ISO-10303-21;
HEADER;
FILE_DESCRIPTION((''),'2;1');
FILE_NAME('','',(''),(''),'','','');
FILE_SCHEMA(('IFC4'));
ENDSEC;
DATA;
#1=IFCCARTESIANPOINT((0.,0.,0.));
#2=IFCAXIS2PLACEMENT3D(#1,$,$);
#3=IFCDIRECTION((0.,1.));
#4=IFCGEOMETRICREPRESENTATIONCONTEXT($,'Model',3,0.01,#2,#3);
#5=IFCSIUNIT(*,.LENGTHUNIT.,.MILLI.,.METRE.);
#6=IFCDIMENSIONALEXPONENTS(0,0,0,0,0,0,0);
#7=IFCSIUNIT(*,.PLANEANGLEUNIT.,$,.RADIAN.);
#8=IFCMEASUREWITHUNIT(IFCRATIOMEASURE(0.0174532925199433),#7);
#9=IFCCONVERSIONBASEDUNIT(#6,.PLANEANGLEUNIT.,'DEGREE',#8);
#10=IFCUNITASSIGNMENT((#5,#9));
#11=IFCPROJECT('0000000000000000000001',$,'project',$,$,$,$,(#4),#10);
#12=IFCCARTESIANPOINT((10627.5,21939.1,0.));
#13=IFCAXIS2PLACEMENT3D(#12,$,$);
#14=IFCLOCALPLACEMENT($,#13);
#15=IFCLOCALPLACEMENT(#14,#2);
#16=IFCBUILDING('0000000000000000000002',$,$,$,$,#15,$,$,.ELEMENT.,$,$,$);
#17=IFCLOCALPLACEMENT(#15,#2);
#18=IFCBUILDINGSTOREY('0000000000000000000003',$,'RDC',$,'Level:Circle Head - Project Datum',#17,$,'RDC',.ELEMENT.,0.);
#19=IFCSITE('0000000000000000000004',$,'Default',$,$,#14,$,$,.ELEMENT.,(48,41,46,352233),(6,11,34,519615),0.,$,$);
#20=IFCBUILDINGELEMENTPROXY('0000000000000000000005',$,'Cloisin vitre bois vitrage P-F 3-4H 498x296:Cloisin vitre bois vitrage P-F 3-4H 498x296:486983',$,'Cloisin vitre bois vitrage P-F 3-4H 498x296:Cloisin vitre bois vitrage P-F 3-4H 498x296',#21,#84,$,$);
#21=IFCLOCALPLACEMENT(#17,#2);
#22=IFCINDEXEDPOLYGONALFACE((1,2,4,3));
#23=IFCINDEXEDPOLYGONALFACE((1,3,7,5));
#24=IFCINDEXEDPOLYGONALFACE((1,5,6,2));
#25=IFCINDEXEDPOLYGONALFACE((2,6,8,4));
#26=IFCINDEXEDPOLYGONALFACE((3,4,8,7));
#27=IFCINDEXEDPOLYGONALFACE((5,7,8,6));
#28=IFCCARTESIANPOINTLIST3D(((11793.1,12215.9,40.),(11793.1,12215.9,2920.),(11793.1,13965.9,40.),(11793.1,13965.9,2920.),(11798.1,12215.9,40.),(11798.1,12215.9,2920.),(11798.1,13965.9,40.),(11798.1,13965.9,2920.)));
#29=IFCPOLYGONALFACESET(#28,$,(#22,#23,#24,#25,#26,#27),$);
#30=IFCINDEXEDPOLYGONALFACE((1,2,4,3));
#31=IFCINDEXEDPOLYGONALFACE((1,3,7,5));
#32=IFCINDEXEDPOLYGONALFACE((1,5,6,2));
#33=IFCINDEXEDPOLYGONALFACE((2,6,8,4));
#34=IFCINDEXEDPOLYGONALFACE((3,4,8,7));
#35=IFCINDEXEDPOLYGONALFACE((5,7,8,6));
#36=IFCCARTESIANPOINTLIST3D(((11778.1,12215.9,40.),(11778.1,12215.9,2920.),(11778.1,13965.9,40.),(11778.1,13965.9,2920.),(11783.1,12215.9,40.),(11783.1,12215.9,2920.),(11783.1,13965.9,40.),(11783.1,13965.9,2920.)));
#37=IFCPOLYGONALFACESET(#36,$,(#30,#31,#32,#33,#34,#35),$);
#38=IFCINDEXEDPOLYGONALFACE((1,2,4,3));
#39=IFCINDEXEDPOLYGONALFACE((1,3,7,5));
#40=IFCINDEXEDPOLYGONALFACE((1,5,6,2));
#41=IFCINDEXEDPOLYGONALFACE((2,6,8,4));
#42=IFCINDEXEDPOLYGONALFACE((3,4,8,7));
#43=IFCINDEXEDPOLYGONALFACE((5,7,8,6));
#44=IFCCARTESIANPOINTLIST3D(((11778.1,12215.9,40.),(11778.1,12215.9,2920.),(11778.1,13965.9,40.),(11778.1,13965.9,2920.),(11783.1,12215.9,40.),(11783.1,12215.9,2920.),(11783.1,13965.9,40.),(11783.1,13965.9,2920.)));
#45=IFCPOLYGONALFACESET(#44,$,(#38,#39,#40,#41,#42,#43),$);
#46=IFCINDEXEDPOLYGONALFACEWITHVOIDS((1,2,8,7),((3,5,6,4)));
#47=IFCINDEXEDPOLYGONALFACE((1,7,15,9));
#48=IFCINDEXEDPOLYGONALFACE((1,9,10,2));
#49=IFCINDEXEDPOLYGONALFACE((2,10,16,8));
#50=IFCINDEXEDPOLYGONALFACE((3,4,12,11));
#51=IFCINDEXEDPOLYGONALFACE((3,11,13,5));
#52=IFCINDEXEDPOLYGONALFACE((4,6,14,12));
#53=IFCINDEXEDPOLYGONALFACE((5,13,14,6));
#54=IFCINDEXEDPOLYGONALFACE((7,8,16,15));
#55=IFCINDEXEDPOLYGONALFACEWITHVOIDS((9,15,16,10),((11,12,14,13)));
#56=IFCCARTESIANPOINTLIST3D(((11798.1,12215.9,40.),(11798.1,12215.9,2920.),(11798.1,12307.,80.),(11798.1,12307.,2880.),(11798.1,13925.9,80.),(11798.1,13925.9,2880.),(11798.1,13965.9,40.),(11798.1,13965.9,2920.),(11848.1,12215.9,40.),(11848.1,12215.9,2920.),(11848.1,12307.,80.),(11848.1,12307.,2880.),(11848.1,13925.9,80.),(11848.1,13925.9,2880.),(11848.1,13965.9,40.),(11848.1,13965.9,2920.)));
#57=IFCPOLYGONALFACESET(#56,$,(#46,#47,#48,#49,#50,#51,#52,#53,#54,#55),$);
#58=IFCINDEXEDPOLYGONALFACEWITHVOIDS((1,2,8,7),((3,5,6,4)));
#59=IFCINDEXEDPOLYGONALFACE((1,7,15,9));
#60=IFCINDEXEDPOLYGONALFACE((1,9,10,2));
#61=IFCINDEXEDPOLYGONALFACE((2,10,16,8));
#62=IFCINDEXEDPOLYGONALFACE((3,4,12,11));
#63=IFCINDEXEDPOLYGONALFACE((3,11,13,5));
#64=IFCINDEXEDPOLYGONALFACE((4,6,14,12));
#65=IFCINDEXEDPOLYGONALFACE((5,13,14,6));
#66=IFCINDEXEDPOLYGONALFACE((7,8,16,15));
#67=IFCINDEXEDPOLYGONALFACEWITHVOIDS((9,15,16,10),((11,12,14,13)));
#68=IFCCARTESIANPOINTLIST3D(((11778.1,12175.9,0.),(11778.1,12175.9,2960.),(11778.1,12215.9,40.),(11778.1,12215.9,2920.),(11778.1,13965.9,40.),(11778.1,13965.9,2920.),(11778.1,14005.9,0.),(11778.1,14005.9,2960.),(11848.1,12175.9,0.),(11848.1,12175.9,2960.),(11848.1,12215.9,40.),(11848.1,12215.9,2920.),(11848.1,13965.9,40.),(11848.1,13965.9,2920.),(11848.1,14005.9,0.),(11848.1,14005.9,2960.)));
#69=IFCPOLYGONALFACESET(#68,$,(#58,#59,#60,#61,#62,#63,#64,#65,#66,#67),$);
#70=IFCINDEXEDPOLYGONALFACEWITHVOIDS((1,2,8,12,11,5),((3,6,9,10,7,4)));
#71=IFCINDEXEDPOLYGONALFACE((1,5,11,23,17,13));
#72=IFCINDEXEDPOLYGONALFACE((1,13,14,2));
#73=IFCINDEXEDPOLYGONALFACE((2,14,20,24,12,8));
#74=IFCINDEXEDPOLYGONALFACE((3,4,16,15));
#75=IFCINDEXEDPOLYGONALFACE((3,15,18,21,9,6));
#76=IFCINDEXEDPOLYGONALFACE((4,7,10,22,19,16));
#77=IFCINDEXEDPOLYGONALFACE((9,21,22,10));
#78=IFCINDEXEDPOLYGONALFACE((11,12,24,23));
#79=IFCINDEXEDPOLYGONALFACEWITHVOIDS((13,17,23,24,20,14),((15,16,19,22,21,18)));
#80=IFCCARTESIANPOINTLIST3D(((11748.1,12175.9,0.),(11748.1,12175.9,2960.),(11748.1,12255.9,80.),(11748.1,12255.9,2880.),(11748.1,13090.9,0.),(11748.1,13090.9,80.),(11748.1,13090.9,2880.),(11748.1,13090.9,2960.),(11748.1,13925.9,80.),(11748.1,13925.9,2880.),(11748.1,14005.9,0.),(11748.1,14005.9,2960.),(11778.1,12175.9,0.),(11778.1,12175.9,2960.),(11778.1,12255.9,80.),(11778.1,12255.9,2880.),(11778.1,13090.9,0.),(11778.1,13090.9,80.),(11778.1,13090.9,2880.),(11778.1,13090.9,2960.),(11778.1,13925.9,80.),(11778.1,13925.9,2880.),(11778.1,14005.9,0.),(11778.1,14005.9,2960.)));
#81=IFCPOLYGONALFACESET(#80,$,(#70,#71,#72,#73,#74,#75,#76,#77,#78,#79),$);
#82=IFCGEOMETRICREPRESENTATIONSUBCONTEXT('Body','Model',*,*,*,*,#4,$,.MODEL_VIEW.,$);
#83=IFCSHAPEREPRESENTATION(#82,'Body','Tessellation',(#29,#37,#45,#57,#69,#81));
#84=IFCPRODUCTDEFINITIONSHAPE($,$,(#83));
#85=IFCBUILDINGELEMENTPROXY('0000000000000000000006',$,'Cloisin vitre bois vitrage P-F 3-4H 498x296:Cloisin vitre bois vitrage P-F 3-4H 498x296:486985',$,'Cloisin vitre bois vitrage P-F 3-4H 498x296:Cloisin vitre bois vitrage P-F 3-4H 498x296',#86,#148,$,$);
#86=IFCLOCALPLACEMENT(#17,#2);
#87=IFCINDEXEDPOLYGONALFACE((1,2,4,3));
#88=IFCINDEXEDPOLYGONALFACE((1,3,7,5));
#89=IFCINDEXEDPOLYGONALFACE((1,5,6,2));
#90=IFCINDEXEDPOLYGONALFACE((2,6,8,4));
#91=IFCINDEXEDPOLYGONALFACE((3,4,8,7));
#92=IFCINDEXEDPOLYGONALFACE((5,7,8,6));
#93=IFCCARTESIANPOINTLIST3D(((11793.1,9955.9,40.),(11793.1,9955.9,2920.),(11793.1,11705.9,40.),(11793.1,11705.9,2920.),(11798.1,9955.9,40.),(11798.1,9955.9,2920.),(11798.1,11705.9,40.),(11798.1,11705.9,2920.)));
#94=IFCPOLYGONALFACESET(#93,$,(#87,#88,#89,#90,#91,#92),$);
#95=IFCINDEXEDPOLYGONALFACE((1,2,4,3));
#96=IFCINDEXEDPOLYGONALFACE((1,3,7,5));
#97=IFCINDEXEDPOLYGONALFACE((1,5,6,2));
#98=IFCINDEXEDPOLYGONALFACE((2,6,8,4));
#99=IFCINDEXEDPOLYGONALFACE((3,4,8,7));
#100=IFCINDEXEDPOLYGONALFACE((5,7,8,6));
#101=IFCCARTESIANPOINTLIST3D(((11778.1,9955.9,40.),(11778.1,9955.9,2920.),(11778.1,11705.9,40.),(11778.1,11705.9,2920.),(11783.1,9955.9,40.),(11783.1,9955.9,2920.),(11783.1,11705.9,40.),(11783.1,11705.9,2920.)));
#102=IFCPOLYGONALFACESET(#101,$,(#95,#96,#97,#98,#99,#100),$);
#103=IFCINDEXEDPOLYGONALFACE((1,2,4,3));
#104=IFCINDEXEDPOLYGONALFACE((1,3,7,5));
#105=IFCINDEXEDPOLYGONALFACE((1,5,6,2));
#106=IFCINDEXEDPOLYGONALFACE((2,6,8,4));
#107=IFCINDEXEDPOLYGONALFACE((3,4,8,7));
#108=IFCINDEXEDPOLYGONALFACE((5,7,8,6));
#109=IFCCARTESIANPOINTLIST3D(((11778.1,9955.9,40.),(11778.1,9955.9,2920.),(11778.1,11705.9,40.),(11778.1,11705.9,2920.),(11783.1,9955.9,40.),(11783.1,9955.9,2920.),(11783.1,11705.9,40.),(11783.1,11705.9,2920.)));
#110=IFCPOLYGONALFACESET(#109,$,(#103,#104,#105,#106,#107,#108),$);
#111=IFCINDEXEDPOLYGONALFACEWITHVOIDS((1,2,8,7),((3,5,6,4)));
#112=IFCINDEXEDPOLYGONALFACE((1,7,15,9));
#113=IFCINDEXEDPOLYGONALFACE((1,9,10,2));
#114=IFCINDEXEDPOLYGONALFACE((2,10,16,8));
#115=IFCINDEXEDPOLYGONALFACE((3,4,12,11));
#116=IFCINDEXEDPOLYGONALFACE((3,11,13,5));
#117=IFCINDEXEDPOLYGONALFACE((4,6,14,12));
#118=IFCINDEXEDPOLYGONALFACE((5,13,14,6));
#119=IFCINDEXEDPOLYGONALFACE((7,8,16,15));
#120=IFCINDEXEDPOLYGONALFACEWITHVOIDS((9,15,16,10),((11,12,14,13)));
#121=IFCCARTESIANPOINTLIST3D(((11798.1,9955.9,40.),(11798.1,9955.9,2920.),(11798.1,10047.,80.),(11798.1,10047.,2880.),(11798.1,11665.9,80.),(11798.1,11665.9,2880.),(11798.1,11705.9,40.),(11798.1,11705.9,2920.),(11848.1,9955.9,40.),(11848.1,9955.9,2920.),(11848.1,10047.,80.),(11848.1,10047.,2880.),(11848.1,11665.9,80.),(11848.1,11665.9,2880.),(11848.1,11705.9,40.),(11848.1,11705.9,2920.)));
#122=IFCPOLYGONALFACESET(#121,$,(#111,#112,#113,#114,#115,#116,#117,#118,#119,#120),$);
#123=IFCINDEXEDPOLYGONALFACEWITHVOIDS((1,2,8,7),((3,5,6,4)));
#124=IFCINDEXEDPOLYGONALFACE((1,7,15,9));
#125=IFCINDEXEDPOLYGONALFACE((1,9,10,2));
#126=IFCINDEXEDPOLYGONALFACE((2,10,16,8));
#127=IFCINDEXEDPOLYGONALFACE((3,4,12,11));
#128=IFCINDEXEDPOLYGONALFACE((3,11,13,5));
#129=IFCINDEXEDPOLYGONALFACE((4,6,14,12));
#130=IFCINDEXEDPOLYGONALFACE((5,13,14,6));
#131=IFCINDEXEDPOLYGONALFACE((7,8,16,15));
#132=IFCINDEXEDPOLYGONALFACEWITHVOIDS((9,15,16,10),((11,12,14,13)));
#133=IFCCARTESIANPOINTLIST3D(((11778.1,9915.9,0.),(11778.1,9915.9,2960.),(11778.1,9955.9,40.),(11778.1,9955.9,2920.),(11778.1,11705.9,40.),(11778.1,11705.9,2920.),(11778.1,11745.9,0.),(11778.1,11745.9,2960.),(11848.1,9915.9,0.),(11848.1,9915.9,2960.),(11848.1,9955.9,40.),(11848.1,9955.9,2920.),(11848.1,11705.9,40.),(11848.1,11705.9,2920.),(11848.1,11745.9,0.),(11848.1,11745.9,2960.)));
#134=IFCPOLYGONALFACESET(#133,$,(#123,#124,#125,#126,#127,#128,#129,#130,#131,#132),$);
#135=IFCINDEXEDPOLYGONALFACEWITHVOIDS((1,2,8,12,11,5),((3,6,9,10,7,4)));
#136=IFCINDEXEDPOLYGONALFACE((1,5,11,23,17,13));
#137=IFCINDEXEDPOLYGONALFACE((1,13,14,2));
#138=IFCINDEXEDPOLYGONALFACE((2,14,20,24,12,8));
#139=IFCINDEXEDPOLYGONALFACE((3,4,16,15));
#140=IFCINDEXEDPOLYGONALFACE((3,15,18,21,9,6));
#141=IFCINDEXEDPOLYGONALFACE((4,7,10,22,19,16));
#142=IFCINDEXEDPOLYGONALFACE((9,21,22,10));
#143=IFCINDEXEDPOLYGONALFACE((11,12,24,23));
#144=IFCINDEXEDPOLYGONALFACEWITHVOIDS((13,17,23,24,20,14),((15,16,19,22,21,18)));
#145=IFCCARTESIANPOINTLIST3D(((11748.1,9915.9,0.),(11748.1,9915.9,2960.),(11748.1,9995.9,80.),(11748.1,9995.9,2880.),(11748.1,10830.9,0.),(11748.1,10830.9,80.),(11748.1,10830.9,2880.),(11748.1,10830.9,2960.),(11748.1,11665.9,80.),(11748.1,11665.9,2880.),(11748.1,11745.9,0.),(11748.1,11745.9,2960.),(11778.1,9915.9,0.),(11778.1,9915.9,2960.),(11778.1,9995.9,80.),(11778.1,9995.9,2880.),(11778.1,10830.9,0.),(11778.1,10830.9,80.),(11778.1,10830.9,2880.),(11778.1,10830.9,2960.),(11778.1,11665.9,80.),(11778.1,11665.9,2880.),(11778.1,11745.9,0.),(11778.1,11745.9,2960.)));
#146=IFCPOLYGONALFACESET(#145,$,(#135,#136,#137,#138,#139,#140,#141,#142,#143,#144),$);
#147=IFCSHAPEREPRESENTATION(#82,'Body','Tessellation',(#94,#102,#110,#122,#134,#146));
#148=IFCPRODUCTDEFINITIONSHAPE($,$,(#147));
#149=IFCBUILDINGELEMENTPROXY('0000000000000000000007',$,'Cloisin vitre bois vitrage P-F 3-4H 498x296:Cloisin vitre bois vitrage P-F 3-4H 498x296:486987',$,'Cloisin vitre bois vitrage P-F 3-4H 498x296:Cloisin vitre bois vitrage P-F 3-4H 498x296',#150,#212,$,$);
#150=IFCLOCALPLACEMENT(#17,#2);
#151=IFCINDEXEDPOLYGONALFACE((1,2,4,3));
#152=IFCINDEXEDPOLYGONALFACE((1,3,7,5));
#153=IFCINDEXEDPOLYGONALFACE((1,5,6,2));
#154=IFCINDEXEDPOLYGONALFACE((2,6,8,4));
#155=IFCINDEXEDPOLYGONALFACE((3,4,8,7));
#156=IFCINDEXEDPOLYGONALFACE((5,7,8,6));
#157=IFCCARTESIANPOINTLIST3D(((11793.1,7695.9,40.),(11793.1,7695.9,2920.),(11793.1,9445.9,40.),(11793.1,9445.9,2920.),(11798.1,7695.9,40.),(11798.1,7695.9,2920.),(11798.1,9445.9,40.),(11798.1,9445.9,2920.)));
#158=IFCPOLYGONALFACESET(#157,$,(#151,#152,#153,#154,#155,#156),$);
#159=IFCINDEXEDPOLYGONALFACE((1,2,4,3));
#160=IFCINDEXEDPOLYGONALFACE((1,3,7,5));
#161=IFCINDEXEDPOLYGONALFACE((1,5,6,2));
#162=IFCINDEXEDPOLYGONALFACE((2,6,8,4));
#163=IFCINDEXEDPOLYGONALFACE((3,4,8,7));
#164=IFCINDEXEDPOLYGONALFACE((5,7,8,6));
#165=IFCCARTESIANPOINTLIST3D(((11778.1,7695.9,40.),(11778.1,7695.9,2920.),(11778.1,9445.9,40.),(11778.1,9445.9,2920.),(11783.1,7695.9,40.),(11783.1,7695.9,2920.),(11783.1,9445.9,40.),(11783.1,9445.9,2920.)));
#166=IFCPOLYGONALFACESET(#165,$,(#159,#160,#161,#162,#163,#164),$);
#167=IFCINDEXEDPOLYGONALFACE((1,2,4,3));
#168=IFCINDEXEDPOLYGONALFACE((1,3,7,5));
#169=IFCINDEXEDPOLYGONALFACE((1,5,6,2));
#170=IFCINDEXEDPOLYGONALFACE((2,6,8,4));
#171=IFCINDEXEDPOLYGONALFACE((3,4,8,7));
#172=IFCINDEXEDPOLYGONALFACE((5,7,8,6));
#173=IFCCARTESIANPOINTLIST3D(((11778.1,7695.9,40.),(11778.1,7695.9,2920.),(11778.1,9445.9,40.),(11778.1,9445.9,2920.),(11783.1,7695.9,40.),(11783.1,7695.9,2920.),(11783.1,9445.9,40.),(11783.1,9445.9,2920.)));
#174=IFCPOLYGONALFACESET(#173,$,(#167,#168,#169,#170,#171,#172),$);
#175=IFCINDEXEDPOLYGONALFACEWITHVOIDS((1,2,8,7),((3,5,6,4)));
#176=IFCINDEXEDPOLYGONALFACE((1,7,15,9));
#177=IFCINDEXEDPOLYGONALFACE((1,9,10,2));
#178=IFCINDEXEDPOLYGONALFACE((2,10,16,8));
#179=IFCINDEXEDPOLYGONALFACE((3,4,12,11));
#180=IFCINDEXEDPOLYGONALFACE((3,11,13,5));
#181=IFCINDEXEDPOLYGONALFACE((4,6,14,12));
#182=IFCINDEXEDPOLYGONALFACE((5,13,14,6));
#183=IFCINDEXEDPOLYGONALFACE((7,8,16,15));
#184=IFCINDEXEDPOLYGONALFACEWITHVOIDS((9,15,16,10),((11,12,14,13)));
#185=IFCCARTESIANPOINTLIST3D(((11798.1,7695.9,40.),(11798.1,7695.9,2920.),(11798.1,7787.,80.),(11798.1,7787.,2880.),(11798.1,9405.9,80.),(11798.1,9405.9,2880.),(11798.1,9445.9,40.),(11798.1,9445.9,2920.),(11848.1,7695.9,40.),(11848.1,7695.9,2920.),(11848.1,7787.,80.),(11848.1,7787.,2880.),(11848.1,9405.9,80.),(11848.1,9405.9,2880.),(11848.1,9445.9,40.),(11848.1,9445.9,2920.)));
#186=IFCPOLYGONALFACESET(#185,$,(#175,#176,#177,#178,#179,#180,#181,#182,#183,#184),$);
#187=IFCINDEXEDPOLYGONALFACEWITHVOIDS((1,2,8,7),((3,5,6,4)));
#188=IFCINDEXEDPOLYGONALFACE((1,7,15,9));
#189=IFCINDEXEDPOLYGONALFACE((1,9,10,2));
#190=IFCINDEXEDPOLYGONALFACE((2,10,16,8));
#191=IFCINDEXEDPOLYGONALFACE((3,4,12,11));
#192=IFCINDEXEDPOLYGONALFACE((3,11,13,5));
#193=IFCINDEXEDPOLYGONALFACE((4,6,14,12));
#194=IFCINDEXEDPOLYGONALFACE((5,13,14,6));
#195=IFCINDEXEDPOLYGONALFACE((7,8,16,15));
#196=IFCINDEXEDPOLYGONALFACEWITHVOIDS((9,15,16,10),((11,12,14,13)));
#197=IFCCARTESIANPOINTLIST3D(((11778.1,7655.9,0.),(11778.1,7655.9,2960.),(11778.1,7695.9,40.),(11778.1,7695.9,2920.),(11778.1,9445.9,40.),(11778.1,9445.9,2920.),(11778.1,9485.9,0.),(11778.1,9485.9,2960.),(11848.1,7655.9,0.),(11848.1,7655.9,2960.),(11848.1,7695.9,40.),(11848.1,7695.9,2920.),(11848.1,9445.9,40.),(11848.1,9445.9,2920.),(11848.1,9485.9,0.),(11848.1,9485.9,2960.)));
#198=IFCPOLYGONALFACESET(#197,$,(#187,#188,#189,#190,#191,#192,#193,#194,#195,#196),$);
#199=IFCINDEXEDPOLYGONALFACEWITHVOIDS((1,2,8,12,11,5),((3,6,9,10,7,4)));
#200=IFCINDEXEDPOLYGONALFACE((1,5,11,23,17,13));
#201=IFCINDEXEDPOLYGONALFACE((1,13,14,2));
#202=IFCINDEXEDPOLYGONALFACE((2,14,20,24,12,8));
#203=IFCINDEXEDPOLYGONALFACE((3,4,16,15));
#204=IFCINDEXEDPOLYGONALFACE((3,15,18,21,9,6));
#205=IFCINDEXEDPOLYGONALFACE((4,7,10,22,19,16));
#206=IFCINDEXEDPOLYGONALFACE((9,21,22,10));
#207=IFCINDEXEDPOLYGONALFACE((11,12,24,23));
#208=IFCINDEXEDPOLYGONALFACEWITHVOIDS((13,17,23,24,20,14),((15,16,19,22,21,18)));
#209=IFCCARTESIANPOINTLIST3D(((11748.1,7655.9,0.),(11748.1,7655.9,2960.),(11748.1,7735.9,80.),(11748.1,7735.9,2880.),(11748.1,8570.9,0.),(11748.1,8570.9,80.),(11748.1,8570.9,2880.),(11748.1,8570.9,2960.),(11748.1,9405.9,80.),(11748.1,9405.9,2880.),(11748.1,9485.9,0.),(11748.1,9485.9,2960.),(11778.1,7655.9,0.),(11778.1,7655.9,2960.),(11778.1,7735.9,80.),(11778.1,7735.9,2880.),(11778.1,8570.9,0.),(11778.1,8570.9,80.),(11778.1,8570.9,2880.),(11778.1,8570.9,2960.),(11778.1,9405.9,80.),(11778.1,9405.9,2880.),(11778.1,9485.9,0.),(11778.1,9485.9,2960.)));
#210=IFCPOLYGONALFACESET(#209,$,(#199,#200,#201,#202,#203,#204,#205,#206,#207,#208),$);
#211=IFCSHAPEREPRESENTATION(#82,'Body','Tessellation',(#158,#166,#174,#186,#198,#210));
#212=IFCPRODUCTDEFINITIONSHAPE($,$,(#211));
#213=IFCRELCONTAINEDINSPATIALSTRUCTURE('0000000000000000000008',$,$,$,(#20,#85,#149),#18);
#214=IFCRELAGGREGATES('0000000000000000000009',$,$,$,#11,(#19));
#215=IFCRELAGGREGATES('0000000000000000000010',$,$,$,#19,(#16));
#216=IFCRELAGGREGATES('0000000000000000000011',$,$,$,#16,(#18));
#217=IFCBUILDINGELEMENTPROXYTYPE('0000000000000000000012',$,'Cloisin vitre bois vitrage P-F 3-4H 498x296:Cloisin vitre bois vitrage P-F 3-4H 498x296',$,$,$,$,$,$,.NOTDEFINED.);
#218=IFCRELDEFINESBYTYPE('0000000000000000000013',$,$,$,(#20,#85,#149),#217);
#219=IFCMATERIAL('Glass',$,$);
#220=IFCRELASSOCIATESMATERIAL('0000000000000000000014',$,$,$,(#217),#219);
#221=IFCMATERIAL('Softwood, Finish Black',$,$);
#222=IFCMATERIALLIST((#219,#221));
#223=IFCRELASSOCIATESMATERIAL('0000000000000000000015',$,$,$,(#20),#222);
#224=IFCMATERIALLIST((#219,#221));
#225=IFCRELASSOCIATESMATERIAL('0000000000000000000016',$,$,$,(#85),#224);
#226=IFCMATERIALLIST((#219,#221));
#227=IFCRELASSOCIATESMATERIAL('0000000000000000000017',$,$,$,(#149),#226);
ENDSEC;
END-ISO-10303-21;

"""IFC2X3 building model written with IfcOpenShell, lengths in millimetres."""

from ifc_helpers import new_model, entity, si_unit, converted_unit, direction, frame, frame_2d, origin, place, context, subcontext, project, spatial, polyline, rectangle, outline, extrude, source, transform, mapped, material, material_list, type_object, type_shapes, element, save


model = new_model("IFC2X3")

# Units and contexts
model_context = context("Model", 3, precision=0.01, world=origin(), true_north=direction((0.0, 1.0)))
body_context = subcontext(model_context, "Body", "Model", "MODEL_VIEW")
ifc_project = project(units=[si_unit("LENGTHUNIT", "METRE", prefix="MILLI"), converted_unit("PLANEANGLEUNIT", "DEGREE", entity("IfcRatioMeasure", 0.0174532925199433), si_unit("PLANEANGLEUNIT", "RADIAN"), dimensions=[0, 0, 0, 0, 0, 0, 0])], contexts=[model_context])

# Site, building, storey
site_placement = place(None, frame((10627.5, 21939.1, 0.0)))
site = spatial("IfcSite", under=ifc_project, at=site_placement, Name="Default", CompositionType="ELEMENT", RefLatitude=(48, 41, 46, 352233), RefLongitude=(6, 11, 34, 519615), RefElevation=0.0)
building_placement = place(site_placement, origin())
building = spatial("IfcBuilding", under=site, at=building_placement, CompositionType="ELEMENT")
storey_placement = place(building_placement, origin())
storey = spatial("IfcBuildingStorey", under=building, at=storey_placement, Name="RDC", ObjectType="Level:Circle Head - Project Datum", LongName="RDC", CompositionType="ELEMENT", Elevation=0.0)

# Building element proxies
ifc_material_1 = material(Name="Glass")
ifc_material_2 = material(Name="Softwood, Finish Black")
ifc_material_list_1 = material_list([ifc_material_1, ifc_material_2])
building_element_proxy_type_1 = type_object("IfcBuildingElementProxyType", Name="Cloisin vitre bois vitrage P-F 3-4H 498x296:Cloisin vitre bois vitrage P-F 3-4H 498x296", PredefinedType="NOTDEFINED", material=ifc_material_1)
shared_shape_1 = source(origin(), body_context, "Body", "SweptSolid", [
    extrude(rectangle(XDim=1750.0, YDim=5.0, at=frame_2d((0.0, 0.0), x_axis=(1.0, 0.0))), frame((0.0, 47.5, 40.0), z_axis=(0.0, 0.0, 1.0), x_axis=(-1.0, 0.0, 0.0)), (0.0, 0.0, 1.0), 2880.0),
    extrude(rectangle(XDim=1750.0, YDim=5.0, at=frame_2d((0.0, 0.0), x_axis=(1.0, 0.0))), frame((0.0, 32.5, 40.0), z_axis=(0.0, 0.0, 1.0), x_axis=(-1.0, 0.0, 0.0)), (0.0, 0.0, 1.0), 2880.0),
    extrude(rectangle(XDim=1750.0, YDim=5.0, at=frame_2d((0.0, 0.0), x_axis=(1.0, 0.0))), frame((0.0, 32.5, 40.0), z_axis=(0.0, 0.0, 1.0), x_axis=(-1.0, 0.0, 0.0)), (0.0, 0.0, 1.0), 2880.0),
    extrude(outline(polyline([(-1440.0, -875.0), (1440.0, -875.0), (1440.0, 875.0), (-1440.0, 875.0), (-1440.0, -875.0)]), holes=[polyline([(1400.0, 835.0), (1400.0, -783.9), (-1400.0, -783.9), (-1400.0, 835.0), (1400.0, 835.0)])]), frame((0.0, 50.0, 1480.0), z_axis=(0.0, 1.0, 0.0), x_axis=(0.0, 0.0, -1.0)), (0.0, 0.0, 1.0), 50.0),
    extrude(outline(polyline([(-1480.0, -915.0), (1480.0, -915.0), (1480.0, 915.0), (-1480.0, 915.0), (-1480.0, -915.0)]), holes=[polyline([(-1440.0, -875.0), (-1440.0, 875.0), (1440.0, 875.0), (1440.0, -875.0), (-1440.0, -875.0)])]), frame((0.0, 30.0, 1480.0), z_axis=(0.0, 1.0, 0.0), x_axis=(0.0, 0.0, -1.0)), (0.0, 0.0, 1.0), 70.0),
    extrude(outline(polyline([(-1480.0, -915.0), (1480.0, -915.0), (1480.0, 0.0), (1480.0, 915.0), (-1480.0, 915.0), (-1480.0, 0.0), (-1480.0, -915.0)]), holes=[polyline([(1400.0, 0.0), (1400.0, -835.0), (-1400.0, -835.0), (-1400.0, 0.0), (-1400.0, 835.0), (1400.0, 835.0), (1400.0, 0.0)])]), frame((0.0, 0.0, 1480.0), z_axis=(0.0, 1.0, 0.0), x_axis=(0.0, 0.0, 1.0)), (0.0, 0.0, 1.0), 30.0),
])
type_shapes(building_element_proxy_type_1, [shared_shape_1])
proxy_1_placement = place(storey_placement, frame((11748.1, 13090.9, 0.0), z_axis=(0.0, 0.0, 1.0), x_axis=(0.0, -1.0, 0.0)))
element("IfcBuildingElementProxy", 1, at=proxy_1_placement, inside=storey, type_object=building_element_proxy_type_1, material=ifc_material_list_1, Name="Cloisin vitre bois vitrage P-F 3-4H 498x296:Cloisin vitre bois vitrage P-F 3-4H 498x296:486983", ObjectType="Cloisin vitre bois vitrage P-F 3-4H 498x296:Cloisin vitre bois vitrage P-F 3-4H 498x296", context=body_context, shape_type="MappedRepresentation", body=[
    mapped(shared_shape_1, transform((0.0, 0.0, 0.0), scale=1.0)),
])
ifc_material_list_2 = material_list([ifc_material_1, ifc_material_2])
proxy_2_placement = place(storey_placement, frame((11748.1, 10830.9, 0.0), z_axis=(0.0, 0.0, 1.0), x_axis=(0.0, -1.0, 0.0)))
element("IfcBuildingElementProxy", 2, at=proxy_2_placement, inside=storey, type_object=building_element_proxy_type_1, material=ifc_material_list_2, Name="Cloisin vitre bois vitrage P-F 3-4H 498x296:Cloisin vitre bois vitrage P-F 3-4H 498x296:486985", ObjectType="Cloisin vitre bois vitrage P-F 3-4H 498x296:Cloisin vitre bois vitrage P-F 3-4H 498x296", context=body_context, shape_type="MappedRepresentation", body=[
    mapped(shared_shape_1, transform((0.0, 0.0, 0.0), scale=1.0)),
])
ifc_material_list_3 = material_list([ifc_material_1, ifc_material_2])
proxy_3_placement = place(storey_placement, frame((11748.1, 8570.9, 0.0), z_axis=(0.0, 0.0, 1.0), x_axis=(0.0, -1.0, 0.0)))
element("IfcBuildingElementProxy", 3, at=proxy_3_placement, inside=storey, type_object=building_element_proxy_type_1, material=ifc_material_list_3, Name="Cloisin vitre bois vitrage P-F 3-4H 498x296:Cloisin vitre bois vitrage P-F 3-4H 498x296:486987", ObjectType="Cloisin vitre bois vitrage P-F 3-4H 498x296:Cloisin vitre bois vitrage P-F 3-4H 498x296", context=body_context, shape_type="MappedRepresentation", body=[
    mapped(shared_shape_1, transform((0.0, 0.0, 0.0), scale=1.0)),
])

save(model, "model.ifc")
